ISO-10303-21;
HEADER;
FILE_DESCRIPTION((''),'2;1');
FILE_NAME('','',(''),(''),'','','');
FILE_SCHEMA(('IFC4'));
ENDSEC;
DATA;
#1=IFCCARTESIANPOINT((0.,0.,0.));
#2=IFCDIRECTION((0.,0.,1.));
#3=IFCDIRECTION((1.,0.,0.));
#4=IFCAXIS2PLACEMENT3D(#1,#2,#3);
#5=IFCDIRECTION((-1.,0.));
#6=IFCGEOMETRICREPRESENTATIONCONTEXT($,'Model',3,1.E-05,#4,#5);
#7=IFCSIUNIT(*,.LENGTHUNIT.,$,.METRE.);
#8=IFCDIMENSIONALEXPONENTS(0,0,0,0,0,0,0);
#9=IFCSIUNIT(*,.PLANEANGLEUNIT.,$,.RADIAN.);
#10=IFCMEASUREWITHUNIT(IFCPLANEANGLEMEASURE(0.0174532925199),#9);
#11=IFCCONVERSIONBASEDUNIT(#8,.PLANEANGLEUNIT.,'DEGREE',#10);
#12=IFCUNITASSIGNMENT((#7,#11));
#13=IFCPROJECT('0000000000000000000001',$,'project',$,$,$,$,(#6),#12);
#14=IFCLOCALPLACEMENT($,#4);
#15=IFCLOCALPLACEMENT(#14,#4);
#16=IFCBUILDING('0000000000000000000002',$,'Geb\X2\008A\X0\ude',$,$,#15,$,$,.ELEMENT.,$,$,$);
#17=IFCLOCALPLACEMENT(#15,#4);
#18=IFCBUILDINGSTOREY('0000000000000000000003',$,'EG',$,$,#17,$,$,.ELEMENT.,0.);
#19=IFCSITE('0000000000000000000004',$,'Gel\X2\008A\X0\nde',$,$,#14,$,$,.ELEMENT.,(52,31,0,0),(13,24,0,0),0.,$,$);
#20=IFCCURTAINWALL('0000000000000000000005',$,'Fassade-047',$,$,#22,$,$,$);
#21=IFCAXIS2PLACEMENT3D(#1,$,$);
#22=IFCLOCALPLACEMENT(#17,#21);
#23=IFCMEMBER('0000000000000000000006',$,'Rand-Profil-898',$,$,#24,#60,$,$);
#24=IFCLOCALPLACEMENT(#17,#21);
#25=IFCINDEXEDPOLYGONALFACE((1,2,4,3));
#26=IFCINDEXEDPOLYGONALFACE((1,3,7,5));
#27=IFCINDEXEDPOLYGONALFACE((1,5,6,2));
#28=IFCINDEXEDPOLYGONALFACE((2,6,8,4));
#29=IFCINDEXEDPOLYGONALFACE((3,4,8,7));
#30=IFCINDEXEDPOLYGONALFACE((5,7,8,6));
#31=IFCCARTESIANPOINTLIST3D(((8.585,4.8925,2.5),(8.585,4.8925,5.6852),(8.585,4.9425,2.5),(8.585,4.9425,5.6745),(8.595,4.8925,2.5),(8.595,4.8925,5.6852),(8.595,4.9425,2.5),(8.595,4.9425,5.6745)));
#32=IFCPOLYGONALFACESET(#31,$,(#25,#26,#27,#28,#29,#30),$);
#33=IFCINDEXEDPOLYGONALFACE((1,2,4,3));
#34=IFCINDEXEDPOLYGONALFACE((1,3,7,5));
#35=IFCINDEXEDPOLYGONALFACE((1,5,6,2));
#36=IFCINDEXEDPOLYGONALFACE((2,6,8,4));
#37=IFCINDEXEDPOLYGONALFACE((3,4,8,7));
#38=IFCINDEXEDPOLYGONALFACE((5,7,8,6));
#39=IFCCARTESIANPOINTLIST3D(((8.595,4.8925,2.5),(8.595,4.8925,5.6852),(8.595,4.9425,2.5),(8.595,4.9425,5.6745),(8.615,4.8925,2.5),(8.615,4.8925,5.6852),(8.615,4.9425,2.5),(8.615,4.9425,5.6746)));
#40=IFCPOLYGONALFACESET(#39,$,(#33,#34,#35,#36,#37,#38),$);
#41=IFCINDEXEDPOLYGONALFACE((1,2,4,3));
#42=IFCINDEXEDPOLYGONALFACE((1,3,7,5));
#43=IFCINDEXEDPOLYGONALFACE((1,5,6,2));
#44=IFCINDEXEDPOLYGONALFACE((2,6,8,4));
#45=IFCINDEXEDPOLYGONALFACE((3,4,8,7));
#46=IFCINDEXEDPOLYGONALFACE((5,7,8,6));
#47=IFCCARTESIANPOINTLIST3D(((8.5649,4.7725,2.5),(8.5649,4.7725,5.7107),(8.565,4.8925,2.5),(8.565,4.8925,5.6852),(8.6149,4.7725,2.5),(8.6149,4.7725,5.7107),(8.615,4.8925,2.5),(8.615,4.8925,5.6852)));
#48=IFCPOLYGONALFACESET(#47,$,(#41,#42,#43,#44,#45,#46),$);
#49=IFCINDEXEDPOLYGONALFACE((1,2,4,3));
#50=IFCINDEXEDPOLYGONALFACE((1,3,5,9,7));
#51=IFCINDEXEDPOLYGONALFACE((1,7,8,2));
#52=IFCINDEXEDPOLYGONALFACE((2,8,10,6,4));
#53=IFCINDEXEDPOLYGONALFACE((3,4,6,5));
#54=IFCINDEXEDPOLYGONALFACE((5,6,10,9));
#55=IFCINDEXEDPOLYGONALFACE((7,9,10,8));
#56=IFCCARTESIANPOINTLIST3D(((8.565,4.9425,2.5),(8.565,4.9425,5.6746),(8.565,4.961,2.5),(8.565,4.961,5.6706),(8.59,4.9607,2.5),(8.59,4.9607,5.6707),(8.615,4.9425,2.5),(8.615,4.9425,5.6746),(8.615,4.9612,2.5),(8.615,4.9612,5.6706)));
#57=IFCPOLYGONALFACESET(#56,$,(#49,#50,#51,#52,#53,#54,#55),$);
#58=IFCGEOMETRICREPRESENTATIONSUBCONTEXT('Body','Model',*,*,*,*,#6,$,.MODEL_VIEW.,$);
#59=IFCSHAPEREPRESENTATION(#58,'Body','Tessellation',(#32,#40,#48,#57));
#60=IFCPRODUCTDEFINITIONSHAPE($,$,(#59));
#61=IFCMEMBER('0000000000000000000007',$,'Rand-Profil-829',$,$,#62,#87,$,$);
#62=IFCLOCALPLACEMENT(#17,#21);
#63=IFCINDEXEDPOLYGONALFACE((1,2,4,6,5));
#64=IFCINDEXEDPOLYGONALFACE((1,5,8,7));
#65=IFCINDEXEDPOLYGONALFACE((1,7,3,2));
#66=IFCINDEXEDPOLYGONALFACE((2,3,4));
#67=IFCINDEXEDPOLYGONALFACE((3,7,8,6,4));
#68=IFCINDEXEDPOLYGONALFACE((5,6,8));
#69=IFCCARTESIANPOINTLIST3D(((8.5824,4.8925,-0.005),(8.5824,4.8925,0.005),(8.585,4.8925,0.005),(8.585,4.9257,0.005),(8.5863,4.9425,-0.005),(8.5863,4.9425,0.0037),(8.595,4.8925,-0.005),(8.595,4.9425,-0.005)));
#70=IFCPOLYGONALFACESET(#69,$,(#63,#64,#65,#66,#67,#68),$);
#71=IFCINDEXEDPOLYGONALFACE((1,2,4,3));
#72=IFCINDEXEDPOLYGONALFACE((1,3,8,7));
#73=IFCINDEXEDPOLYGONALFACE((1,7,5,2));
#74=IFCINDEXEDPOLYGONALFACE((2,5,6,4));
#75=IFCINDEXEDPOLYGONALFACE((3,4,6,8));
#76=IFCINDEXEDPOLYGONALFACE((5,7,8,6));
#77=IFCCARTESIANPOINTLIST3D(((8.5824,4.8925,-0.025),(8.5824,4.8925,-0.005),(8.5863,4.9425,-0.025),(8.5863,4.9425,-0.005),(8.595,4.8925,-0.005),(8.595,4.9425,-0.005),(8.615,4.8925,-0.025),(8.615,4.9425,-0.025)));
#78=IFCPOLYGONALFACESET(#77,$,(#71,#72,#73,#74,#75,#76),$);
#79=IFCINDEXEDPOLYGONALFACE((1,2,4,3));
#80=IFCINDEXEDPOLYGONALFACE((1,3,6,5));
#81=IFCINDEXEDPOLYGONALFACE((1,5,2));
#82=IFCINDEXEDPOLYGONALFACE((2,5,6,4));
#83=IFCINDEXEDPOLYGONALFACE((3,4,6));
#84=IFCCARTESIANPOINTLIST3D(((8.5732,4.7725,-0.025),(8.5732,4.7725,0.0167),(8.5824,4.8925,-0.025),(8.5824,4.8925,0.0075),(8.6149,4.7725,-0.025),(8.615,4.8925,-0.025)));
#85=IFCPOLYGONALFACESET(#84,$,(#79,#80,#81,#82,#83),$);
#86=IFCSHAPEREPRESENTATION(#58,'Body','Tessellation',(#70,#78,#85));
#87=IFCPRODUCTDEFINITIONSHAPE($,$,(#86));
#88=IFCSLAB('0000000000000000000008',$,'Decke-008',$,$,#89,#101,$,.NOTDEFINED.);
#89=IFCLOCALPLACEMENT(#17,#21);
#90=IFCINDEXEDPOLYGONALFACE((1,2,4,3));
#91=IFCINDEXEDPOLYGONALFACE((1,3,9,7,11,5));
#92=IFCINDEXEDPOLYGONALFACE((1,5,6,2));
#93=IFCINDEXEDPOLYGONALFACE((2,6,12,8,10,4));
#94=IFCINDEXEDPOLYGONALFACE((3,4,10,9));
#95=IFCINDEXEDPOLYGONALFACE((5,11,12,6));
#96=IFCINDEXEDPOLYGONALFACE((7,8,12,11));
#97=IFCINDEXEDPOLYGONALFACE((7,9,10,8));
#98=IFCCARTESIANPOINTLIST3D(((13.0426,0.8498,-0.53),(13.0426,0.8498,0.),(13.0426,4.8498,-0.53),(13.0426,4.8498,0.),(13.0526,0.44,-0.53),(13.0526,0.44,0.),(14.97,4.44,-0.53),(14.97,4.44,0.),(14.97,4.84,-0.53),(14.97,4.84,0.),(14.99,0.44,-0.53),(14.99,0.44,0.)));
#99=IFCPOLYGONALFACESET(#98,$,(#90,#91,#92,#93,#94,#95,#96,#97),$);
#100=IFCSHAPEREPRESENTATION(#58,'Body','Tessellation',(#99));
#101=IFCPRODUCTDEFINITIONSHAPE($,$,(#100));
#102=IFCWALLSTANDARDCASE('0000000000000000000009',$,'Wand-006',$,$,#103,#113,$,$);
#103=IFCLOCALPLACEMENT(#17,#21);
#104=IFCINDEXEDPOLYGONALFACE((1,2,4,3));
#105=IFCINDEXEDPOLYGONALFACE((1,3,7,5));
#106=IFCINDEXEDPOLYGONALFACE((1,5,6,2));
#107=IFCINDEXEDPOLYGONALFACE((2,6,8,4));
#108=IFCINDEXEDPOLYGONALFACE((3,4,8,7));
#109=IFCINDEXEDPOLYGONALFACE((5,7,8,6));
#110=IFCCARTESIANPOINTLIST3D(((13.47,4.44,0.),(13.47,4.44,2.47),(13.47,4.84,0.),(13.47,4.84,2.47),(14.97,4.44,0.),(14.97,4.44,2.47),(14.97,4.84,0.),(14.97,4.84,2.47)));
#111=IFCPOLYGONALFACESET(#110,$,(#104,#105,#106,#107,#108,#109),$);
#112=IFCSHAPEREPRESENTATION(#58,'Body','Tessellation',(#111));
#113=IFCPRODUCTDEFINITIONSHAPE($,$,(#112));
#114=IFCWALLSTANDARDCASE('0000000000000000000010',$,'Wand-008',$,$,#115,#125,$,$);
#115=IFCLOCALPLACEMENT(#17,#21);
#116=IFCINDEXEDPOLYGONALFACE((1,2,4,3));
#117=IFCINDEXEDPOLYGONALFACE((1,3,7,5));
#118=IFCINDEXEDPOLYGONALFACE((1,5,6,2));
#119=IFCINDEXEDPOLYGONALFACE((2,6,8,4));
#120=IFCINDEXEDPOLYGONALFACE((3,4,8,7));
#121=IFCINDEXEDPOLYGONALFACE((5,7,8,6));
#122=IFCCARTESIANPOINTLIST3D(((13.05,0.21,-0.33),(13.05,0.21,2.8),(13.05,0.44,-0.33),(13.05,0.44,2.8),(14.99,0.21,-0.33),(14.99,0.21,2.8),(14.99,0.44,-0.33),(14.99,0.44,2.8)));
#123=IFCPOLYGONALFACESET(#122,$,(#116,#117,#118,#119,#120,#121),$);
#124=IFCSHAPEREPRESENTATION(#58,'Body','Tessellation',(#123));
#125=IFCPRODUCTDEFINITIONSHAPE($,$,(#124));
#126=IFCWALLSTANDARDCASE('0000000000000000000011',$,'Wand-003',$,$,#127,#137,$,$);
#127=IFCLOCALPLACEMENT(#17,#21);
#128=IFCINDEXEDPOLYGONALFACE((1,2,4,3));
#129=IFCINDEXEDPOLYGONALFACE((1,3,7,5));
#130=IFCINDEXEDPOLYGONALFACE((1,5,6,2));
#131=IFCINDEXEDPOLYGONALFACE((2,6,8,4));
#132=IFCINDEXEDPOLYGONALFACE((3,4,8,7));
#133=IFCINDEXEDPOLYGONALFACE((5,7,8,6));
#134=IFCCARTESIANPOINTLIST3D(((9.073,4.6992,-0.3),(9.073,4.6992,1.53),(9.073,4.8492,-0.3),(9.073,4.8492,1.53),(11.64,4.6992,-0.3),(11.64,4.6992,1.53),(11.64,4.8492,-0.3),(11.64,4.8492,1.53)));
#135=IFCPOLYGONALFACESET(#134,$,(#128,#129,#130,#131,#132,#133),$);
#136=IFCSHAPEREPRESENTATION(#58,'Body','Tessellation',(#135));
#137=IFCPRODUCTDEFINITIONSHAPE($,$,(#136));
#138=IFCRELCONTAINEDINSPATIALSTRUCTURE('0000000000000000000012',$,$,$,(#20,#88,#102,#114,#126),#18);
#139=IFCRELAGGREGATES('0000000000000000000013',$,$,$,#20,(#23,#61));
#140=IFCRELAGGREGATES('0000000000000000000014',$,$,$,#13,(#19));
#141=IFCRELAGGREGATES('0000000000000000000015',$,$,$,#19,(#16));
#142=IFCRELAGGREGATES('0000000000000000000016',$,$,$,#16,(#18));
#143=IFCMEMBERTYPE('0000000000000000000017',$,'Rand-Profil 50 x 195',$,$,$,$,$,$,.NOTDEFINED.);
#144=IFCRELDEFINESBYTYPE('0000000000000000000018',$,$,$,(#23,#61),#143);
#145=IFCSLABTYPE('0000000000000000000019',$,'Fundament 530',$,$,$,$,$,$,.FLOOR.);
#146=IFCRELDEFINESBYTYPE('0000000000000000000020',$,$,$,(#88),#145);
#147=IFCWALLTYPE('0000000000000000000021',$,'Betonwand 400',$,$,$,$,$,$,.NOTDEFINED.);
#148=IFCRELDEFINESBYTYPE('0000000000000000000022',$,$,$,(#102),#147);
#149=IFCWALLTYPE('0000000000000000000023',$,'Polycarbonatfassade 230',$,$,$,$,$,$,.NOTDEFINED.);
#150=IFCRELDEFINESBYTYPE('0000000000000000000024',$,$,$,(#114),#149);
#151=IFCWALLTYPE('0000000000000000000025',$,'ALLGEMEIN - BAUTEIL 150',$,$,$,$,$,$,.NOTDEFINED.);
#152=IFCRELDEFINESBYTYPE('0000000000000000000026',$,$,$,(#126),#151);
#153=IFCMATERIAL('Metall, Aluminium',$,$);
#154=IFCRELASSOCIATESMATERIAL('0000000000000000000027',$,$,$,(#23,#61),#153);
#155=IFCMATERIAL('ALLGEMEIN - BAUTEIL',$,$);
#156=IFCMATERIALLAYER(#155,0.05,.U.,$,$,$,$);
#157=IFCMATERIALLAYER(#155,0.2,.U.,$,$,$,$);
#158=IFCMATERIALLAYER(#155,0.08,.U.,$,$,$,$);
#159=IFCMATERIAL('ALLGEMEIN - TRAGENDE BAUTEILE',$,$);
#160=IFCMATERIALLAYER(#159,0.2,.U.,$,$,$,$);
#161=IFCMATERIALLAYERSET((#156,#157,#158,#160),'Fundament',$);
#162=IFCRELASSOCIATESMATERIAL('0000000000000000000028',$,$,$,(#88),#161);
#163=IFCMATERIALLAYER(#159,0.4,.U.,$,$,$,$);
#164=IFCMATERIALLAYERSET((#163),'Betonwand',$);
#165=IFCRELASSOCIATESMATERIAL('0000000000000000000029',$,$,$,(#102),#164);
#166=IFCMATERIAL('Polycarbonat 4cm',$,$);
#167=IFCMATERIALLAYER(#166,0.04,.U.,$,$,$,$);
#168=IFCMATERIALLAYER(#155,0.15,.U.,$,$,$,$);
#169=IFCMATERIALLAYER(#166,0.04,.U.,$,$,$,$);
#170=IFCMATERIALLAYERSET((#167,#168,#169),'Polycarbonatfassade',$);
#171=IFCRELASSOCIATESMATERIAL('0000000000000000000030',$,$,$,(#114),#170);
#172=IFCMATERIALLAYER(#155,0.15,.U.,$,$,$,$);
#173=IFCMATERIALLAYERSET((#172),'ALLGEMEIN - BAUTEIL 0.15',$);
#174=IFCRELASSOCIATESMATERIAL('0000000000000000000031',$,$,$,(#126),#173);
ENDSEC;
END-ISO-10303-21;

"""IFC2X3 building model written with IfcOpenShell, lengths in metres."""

from ifc_helpers import new_model, entity, si_unit, converted_unit, direction, frame, origin_with_axes, place, context, subcontext, project, spatial, polyline, outline, extrude, clip, halfspace, material, layer, layer_set, layer_usage, type_object, element, aggregate, save


model = new_model("IFC2X3")

# Units and contexts
model_context = context("Model", 3, precision=1e-05, world=origin_with_axes(), true_north=direction((-1.0, 0.0)))
body_context = subcontext(model_context, "Body", "Model", "MODEL_VIEW")
ifc_project = project(units=[si_unit("LENGTHUNIT", "METRE"), converted_unit("PLANEANGLEUNIT", "DEGREE", entity("IfcPlaneAngleMeasure", 0.0174532925199), si_unit("PLANEANGLEUNIT", "RADIAN"), dimensions=[0, 0, 0, 0, 0, 0, 0])], contexts=[model_context])

# Site, building, storey
site_placement = place(None, origin_with_axes())
site = spatial("IfcSite", under=ifc_project, at=site_placement, Name="Gel\u008ande", CompositionType="ELEMENT", RefLatitude=(52, 31, 0, 0), RefLongitude=(13, 24, 0, 0), RefElevation=0.0)
building_placement = place(site_placement, origin_with_axes())
building = spatial("IfcBuilding", under=site, at=building_placement, Name="Geb\u008aude", CompositionType="ELEMENT")
storey_placement = place(building_placement, origin_with_axes())
storey = spatial("IfcBuildingStorey", under=building, at=storey_placement, Name="EG", CompositionType="ELEMENT", Elevation=0.0)

# Curtain wall, members
curtain_wall_placement = place(storey_placement, frame((7.6056, 12.5904, 0.0), z_axis=(0.0, 0.0, 1.0), x_axis=(1.0, 0.0, 0.0)))
curtain_wall = element("IfcCurtainWall", 1, at=curtain_wall_placement, inside=storey, Name="Fassade-047")
ifc_material_1 = material(Name="Metall, Aluminium")
member_type_1 = type_object("IfcMemberType", Name="Rand-Profil 50 x 195", PredefinedType="NOTDEFINED")
member_1_placement = place(curtain_wall_placement, frame((0.9844, -7.6729, 2.5), z_axis=(0.0, 0.0, 1.0), x_axis=(-1.0, 0.000717, 0.0)))
member_1 = element("IfcMember", 2, at=member_1_placement, type_object=member_type_1, material=ifc_material_1, Name="Rand-Profil-898", context=body_context, shape_type="Clipping", body=[
    clip(extrude(outline(polyline([(0.005, 0.025), (-0.005, 0.025), (-0.005, -0.025), (0.005, -0.025), (0.005, 0.025)])), frame((0.0, 0.0, 0.0), z_axis=(0.0, 0.0, 1.0), x_axis=(-1.0, -0.000717, 0.0)), (0.0, 0.0, 1.0), 3.1852), halfspace(frame((0.0005, -0.6467, 3.0424), z_axis=(-0.000149, 0.207912, -0.978148), x_axis=(0.0, -0.978148, -0.207912)), True)),
    clip(extrude(outline(polyline([(0.025, 0.025), (0.005, 0.025), (0.005, -0.025), (0.025, -0.025), (0.025, 0.025)])), frame((0.0, 0.0, 0.0), z_axis=(0.0, 0.0, 1.0), x_axis=(-1.0, -0.000717, 0.0)), (0.0, 0.0, 1.0), 3.1852), halfspace(frame((0.0005, -0.6467, 3.0424), z_axis=(-0.000149, 0.207912, -0.978148), x_axis=(0.0, -0.978148, -0.207912)), True)),
    clip(extrude(outline(polyline([(0.025, -0.025), (-0.025, -0.025), (-0.0251, -0.145), (0.0249, -0.145), (0.025, -0.025)])), frame((0.0, 0.0, 0.0), z_axis=(0.0, 0.0, 1.0), x_axis=(-1.0, -0.000717, 0.0)), (0.0, 0.0, 1.0), 3.2107), halfspace(frame((0.0005, -0.6467, 3.0424), z_axis=(-0.000149, 0.207912, -0.978148), x_axis=(0.0, -0.978148, -0.207912)), True)),
    clip(extrude(outline(polyline([(0.025, 0.025), (0.025, 0.0437), (0.0, 0.0432), (-0.025, 0.0435), (-0.025, 0.025), (0.025, 0.025)])), frame((0.0, 0.0, 0.0), z_axis=(0.0, 0.0, 1.0), x_axis=(-1.0, -0.000717, 0.0)), (0.0, 0.0, 1.0), 3.1746), halfspace(frame((0.0005, -0.6467, 3.0424), z_axis=(-0.000149, 0.207912, -0.978148), x_axis=(0.0, -0.978148, -0.207912)), True)),
])
member_2_placement = place(curtain_wall_placement, frame((0.9788, -7.6729, 0.0), z_axis=(1.0, -0.000717, 0.0), x_axis=(0.0, 0.0, 1.0)))
member_2 = element("IfcMember", 3, at=member_2_placement, type_object=member_type_1, material=ifc_material_1, Name="Rand-Profil-829", context=body_context, shape_type="Clipping", body=[
    clip(clip(extrude(outline(polyline([(0.025, -0.005), (0.025, 0.005), (-0.025, 0.005), (-0.025, -0.0037), (-0.0082, -0.005), (0.025, -0.005)])), frame((0.0, 0.0, -0.0019), z_axis=(0.0, 0.0, 1.0), x_axis=(0.0, 1.0, 0.0)), (0.0, 0.0, 1.0), 0.0125), halfspace(frame((0.0028, 0.0, 0.0028), z_axis=(-0.707107, 0.0, -0.707107), x_axis=(0.707107, 0.0, -0.707107)), True)), halfspace(frame((0.0, 0.0, 0.0), z_axis=(0.0, 0.076165, 0.997095), x_axis=(0.0, 0.997095, -0.076165)), True)),
    clip(clip(extrude(outline(polyline([(0.025, 0.005), (0.025, 0.025), (-0.025, 0.025), (-0.025, 0.005), (0.025, 0.005)])), frame((0.0, 0.0, -0.0019), z_axis=(0.0, 0.0, 1.0), x_axis=(0.0, 1.0, 0.0)), (0.0, 0.0, 1.0), 0.0325), halfspace(frame((0.0028, 0.0, 0.0028), z_axis=(-0.707107, 0.0, -0.707107), x_axis=(0.707107, 0.0, -0.707107)), True)), halfspace(frame((0.0, 0.0, 0.0), z_axis=(0.0, 0.076165, 0.997095), x_axis=(0.0, 0.997095, -0.076165)), True)),
    clip(clip(extrude(outline(polyline([(0.145, -0.0167), (0.145, 0.025), (0.025, 0.025), (0.025, -0.0075), (0.145, -0.0167)])), frame((0.0, 0.0, -0.0111), z_axis=(0.0, 0.0, 1.0), x_axis=(0.0, 1.0, 0.0)), (0.0, 0.0, 1.0), 0.0417), halfspace(frame((0.0, 0.0, 0.0), z_axis=(0.0, 0.076165, 0.997095), x_axis=(0.0, 0.997095, -0.076165)), True)), halfspace(frame((0.0028, 0.0, 0.0028), z_axis=(-0.707107, 0.0, -0.707107), x_axis=(0.707107, 0.0, -0.707107)), True)),
])

# Slab
ifc_material_2 = material(Name="ALLGEMEIN - BAUTEIL")
ifc_layer_1 = layer(ifc_material_2, 0.05, ventilated="UNKNOWN")
ifc_layer_2 = layer(ifc_material_2, 0.2, ventilated="UNKNOWN")
ifc_layer_3 = layer(ifc_material_2, 0.08, ventilated="UNKNOWN")
ifc_material_3 = material(Name="ALLGEMEIN - TRAGENDE BAUTEILE")
ifc_layer_4 = layer(ifc_material_3, 0.2, ventilated="UNKNOWN")
ifc_layer_set_1 = layer_set([ifc_layer_1, ifc_layer_2, ifc_layer_3, ifc_layer_4], Name="Fundament")
ifc_layer_usage_1 = layer_usage(ifc_layer_set_1, "AXIS3", "NEGATIVE", 0.53)
slab_type = type_object("IfcSlabType", Name="Fundament 530", PredefinedType="FLOOR")
slab_placement = place(storey_placement, frame((13.0426, 0.8498, 0.0), z_axis=(0.0, 0.0, 1.0), x_axis=(1.0, 0.0, 0.0)))
element("IfcSlab", 4, at=slab_placement, inside=storey, type_object=slab_type, material=ifc_layer_usage_1, Name="Decke-008", PredefinedType="NOTDEFINED", context=body_context, shape_type="SweptSolid", body=[
    extrude(outline(polyline([(0.0, 0.0), (0.01, -0.4098), (1.9474, -0.4098), (1.9274, 3.5902), (1.9274, 3.9902), (0.0, 4.0), (0.0, 0.0)])), frame((0.0, 0.0, -0.53), z_axis=(0.0, 0.0, 1.0), x_axis=(1.0, 0.0, 0.0)), (0.0, 0.0, 1.0), 0.53),
])

aggregate(curtain_wall, [member_1, member_2])

# Walls
ifc_layer_5 = layer(ifc_material_3, 0.4, ventilated="UNKNOWN")
ifc_layer_set_2 = layer_set([ifc_layer_5], Name="Betonwand")
ifc_layer_usage_2 = layer_usage(ifc_layer_set_2, "AXIS2", "POSITIVE", -0.4)
wall_type_1 = type_object("IfcWallType", Name="Betonwand 400", PredefinedType="NOTDEFINED")
wall_1_placement = place(storey_placement, frame((13.47, 4.84, 0.0), z_axis=(0.0, 0.0, 1.0), x_axis=(1.0, 0.0, 0.0)))
element("IfcWallStandardCase", 5, at=wall_1_placement, inside=storey, type_object=wall_type_1, material=ifc_layer_usage_2, Name="Wand-006", context=body_context, shape_type="SweptSolid", body=[
    extrude(outline(polyline([(0.0, -0.4), (1.5, -0.4), (1.5, 0.0), (0.0, 0.0), (0.0, -0.4)])), origin_with_axes(), (0.0, 0.0, 1.0), 2.47),
])
ifc_material_4 = material(Name="Polycarbonat 4cm")
ifc_layer_6 = layer(ifc_material_4, 0.04, ventilated="UNKNOWN")
ifc_layer_7 = layer(ifc_material_2, 0.15, ventilated="UNKNOWN")
ifc_layer_8 = layer(ifc_material_4, 0.04, ventilated="UNKNOWN")
ifc_layer_set_3 = layer_set([ifc_layer_6, ifc_layer_7, ifc_layer_8], Name="Polycarbonatfassade")
ifc_layer_usage_3 = layer_usage(ifc_layer_set_3, "AXIS2", "NEGATIVE", 0.0)
wall_type_2 = type_object("IfcWallType", Name="Polycarbonatfassade 230", PredefinedType="NOTDEFINED")
wall_2_placement = place(storey_placement, frame((13.05, 0.44, -0.33), z_axis=(0.0, 0.0, 1.0), x_axis=(1.0, 0.0, 0.0)))
element("IfcWallStandardCase", 6, at=wall_2_placement, inside=storey, type_object=wall_type_2, material=ifc_layer_usage_3, Name="Wand-008", context=body_context, shape_type="SweptSolid", body=[
    extrude(outline(polyline([(0.0, -0.23), (1.94, -0.23), (1.94, 0.0), (0.0, 0.0), (0.0, -0.23)])), origin_with_axes(), (0.0, 0.0, 1.0), 3.13),
])
ifc_layer_9 = layer(ifc_material_2, 0.15, ventilated="UNKNOWN")
ifc_layer_set_4 = layer_set([ifc_layer_9], Name="ALLGEMEIN - BAUTEIL 0.15")
ifc_layer_usage_4 = layer_usage(ifc_layer_set_4, "AXIS2", "POSITIVE", -0.15)
wall_type_3 = type_object("IfcWallType", Name="ALLGEMEIN - BAUTEIL 150", PredefinedType="NOTDEFINED")
wall_3_placement = place(storey_placement, frame((11.64, 4.6992, -0.3), z_axis=(0.0, 0.0, 1.0), x_axis=(-1.0, 0.0, 0.0)))
element("IfcWallStandardCase", 7, at=wall_3_placement, inside=storey, type_object=wall_type_3, material=ifc_layer_usage_4, Name="Wand-003", context=body_context, shape_type="SweptSolid", body=[
    extrude(outline(polyline([(0.0, -0.15), (2.567, -0.15), (2.567, 0.0), (0.0, 0.0), (0.0, -0.15)])), origin_with_axes(), (0.0, 0.0, 1.0), 1.83),
])

save(model, "model.ifc")
